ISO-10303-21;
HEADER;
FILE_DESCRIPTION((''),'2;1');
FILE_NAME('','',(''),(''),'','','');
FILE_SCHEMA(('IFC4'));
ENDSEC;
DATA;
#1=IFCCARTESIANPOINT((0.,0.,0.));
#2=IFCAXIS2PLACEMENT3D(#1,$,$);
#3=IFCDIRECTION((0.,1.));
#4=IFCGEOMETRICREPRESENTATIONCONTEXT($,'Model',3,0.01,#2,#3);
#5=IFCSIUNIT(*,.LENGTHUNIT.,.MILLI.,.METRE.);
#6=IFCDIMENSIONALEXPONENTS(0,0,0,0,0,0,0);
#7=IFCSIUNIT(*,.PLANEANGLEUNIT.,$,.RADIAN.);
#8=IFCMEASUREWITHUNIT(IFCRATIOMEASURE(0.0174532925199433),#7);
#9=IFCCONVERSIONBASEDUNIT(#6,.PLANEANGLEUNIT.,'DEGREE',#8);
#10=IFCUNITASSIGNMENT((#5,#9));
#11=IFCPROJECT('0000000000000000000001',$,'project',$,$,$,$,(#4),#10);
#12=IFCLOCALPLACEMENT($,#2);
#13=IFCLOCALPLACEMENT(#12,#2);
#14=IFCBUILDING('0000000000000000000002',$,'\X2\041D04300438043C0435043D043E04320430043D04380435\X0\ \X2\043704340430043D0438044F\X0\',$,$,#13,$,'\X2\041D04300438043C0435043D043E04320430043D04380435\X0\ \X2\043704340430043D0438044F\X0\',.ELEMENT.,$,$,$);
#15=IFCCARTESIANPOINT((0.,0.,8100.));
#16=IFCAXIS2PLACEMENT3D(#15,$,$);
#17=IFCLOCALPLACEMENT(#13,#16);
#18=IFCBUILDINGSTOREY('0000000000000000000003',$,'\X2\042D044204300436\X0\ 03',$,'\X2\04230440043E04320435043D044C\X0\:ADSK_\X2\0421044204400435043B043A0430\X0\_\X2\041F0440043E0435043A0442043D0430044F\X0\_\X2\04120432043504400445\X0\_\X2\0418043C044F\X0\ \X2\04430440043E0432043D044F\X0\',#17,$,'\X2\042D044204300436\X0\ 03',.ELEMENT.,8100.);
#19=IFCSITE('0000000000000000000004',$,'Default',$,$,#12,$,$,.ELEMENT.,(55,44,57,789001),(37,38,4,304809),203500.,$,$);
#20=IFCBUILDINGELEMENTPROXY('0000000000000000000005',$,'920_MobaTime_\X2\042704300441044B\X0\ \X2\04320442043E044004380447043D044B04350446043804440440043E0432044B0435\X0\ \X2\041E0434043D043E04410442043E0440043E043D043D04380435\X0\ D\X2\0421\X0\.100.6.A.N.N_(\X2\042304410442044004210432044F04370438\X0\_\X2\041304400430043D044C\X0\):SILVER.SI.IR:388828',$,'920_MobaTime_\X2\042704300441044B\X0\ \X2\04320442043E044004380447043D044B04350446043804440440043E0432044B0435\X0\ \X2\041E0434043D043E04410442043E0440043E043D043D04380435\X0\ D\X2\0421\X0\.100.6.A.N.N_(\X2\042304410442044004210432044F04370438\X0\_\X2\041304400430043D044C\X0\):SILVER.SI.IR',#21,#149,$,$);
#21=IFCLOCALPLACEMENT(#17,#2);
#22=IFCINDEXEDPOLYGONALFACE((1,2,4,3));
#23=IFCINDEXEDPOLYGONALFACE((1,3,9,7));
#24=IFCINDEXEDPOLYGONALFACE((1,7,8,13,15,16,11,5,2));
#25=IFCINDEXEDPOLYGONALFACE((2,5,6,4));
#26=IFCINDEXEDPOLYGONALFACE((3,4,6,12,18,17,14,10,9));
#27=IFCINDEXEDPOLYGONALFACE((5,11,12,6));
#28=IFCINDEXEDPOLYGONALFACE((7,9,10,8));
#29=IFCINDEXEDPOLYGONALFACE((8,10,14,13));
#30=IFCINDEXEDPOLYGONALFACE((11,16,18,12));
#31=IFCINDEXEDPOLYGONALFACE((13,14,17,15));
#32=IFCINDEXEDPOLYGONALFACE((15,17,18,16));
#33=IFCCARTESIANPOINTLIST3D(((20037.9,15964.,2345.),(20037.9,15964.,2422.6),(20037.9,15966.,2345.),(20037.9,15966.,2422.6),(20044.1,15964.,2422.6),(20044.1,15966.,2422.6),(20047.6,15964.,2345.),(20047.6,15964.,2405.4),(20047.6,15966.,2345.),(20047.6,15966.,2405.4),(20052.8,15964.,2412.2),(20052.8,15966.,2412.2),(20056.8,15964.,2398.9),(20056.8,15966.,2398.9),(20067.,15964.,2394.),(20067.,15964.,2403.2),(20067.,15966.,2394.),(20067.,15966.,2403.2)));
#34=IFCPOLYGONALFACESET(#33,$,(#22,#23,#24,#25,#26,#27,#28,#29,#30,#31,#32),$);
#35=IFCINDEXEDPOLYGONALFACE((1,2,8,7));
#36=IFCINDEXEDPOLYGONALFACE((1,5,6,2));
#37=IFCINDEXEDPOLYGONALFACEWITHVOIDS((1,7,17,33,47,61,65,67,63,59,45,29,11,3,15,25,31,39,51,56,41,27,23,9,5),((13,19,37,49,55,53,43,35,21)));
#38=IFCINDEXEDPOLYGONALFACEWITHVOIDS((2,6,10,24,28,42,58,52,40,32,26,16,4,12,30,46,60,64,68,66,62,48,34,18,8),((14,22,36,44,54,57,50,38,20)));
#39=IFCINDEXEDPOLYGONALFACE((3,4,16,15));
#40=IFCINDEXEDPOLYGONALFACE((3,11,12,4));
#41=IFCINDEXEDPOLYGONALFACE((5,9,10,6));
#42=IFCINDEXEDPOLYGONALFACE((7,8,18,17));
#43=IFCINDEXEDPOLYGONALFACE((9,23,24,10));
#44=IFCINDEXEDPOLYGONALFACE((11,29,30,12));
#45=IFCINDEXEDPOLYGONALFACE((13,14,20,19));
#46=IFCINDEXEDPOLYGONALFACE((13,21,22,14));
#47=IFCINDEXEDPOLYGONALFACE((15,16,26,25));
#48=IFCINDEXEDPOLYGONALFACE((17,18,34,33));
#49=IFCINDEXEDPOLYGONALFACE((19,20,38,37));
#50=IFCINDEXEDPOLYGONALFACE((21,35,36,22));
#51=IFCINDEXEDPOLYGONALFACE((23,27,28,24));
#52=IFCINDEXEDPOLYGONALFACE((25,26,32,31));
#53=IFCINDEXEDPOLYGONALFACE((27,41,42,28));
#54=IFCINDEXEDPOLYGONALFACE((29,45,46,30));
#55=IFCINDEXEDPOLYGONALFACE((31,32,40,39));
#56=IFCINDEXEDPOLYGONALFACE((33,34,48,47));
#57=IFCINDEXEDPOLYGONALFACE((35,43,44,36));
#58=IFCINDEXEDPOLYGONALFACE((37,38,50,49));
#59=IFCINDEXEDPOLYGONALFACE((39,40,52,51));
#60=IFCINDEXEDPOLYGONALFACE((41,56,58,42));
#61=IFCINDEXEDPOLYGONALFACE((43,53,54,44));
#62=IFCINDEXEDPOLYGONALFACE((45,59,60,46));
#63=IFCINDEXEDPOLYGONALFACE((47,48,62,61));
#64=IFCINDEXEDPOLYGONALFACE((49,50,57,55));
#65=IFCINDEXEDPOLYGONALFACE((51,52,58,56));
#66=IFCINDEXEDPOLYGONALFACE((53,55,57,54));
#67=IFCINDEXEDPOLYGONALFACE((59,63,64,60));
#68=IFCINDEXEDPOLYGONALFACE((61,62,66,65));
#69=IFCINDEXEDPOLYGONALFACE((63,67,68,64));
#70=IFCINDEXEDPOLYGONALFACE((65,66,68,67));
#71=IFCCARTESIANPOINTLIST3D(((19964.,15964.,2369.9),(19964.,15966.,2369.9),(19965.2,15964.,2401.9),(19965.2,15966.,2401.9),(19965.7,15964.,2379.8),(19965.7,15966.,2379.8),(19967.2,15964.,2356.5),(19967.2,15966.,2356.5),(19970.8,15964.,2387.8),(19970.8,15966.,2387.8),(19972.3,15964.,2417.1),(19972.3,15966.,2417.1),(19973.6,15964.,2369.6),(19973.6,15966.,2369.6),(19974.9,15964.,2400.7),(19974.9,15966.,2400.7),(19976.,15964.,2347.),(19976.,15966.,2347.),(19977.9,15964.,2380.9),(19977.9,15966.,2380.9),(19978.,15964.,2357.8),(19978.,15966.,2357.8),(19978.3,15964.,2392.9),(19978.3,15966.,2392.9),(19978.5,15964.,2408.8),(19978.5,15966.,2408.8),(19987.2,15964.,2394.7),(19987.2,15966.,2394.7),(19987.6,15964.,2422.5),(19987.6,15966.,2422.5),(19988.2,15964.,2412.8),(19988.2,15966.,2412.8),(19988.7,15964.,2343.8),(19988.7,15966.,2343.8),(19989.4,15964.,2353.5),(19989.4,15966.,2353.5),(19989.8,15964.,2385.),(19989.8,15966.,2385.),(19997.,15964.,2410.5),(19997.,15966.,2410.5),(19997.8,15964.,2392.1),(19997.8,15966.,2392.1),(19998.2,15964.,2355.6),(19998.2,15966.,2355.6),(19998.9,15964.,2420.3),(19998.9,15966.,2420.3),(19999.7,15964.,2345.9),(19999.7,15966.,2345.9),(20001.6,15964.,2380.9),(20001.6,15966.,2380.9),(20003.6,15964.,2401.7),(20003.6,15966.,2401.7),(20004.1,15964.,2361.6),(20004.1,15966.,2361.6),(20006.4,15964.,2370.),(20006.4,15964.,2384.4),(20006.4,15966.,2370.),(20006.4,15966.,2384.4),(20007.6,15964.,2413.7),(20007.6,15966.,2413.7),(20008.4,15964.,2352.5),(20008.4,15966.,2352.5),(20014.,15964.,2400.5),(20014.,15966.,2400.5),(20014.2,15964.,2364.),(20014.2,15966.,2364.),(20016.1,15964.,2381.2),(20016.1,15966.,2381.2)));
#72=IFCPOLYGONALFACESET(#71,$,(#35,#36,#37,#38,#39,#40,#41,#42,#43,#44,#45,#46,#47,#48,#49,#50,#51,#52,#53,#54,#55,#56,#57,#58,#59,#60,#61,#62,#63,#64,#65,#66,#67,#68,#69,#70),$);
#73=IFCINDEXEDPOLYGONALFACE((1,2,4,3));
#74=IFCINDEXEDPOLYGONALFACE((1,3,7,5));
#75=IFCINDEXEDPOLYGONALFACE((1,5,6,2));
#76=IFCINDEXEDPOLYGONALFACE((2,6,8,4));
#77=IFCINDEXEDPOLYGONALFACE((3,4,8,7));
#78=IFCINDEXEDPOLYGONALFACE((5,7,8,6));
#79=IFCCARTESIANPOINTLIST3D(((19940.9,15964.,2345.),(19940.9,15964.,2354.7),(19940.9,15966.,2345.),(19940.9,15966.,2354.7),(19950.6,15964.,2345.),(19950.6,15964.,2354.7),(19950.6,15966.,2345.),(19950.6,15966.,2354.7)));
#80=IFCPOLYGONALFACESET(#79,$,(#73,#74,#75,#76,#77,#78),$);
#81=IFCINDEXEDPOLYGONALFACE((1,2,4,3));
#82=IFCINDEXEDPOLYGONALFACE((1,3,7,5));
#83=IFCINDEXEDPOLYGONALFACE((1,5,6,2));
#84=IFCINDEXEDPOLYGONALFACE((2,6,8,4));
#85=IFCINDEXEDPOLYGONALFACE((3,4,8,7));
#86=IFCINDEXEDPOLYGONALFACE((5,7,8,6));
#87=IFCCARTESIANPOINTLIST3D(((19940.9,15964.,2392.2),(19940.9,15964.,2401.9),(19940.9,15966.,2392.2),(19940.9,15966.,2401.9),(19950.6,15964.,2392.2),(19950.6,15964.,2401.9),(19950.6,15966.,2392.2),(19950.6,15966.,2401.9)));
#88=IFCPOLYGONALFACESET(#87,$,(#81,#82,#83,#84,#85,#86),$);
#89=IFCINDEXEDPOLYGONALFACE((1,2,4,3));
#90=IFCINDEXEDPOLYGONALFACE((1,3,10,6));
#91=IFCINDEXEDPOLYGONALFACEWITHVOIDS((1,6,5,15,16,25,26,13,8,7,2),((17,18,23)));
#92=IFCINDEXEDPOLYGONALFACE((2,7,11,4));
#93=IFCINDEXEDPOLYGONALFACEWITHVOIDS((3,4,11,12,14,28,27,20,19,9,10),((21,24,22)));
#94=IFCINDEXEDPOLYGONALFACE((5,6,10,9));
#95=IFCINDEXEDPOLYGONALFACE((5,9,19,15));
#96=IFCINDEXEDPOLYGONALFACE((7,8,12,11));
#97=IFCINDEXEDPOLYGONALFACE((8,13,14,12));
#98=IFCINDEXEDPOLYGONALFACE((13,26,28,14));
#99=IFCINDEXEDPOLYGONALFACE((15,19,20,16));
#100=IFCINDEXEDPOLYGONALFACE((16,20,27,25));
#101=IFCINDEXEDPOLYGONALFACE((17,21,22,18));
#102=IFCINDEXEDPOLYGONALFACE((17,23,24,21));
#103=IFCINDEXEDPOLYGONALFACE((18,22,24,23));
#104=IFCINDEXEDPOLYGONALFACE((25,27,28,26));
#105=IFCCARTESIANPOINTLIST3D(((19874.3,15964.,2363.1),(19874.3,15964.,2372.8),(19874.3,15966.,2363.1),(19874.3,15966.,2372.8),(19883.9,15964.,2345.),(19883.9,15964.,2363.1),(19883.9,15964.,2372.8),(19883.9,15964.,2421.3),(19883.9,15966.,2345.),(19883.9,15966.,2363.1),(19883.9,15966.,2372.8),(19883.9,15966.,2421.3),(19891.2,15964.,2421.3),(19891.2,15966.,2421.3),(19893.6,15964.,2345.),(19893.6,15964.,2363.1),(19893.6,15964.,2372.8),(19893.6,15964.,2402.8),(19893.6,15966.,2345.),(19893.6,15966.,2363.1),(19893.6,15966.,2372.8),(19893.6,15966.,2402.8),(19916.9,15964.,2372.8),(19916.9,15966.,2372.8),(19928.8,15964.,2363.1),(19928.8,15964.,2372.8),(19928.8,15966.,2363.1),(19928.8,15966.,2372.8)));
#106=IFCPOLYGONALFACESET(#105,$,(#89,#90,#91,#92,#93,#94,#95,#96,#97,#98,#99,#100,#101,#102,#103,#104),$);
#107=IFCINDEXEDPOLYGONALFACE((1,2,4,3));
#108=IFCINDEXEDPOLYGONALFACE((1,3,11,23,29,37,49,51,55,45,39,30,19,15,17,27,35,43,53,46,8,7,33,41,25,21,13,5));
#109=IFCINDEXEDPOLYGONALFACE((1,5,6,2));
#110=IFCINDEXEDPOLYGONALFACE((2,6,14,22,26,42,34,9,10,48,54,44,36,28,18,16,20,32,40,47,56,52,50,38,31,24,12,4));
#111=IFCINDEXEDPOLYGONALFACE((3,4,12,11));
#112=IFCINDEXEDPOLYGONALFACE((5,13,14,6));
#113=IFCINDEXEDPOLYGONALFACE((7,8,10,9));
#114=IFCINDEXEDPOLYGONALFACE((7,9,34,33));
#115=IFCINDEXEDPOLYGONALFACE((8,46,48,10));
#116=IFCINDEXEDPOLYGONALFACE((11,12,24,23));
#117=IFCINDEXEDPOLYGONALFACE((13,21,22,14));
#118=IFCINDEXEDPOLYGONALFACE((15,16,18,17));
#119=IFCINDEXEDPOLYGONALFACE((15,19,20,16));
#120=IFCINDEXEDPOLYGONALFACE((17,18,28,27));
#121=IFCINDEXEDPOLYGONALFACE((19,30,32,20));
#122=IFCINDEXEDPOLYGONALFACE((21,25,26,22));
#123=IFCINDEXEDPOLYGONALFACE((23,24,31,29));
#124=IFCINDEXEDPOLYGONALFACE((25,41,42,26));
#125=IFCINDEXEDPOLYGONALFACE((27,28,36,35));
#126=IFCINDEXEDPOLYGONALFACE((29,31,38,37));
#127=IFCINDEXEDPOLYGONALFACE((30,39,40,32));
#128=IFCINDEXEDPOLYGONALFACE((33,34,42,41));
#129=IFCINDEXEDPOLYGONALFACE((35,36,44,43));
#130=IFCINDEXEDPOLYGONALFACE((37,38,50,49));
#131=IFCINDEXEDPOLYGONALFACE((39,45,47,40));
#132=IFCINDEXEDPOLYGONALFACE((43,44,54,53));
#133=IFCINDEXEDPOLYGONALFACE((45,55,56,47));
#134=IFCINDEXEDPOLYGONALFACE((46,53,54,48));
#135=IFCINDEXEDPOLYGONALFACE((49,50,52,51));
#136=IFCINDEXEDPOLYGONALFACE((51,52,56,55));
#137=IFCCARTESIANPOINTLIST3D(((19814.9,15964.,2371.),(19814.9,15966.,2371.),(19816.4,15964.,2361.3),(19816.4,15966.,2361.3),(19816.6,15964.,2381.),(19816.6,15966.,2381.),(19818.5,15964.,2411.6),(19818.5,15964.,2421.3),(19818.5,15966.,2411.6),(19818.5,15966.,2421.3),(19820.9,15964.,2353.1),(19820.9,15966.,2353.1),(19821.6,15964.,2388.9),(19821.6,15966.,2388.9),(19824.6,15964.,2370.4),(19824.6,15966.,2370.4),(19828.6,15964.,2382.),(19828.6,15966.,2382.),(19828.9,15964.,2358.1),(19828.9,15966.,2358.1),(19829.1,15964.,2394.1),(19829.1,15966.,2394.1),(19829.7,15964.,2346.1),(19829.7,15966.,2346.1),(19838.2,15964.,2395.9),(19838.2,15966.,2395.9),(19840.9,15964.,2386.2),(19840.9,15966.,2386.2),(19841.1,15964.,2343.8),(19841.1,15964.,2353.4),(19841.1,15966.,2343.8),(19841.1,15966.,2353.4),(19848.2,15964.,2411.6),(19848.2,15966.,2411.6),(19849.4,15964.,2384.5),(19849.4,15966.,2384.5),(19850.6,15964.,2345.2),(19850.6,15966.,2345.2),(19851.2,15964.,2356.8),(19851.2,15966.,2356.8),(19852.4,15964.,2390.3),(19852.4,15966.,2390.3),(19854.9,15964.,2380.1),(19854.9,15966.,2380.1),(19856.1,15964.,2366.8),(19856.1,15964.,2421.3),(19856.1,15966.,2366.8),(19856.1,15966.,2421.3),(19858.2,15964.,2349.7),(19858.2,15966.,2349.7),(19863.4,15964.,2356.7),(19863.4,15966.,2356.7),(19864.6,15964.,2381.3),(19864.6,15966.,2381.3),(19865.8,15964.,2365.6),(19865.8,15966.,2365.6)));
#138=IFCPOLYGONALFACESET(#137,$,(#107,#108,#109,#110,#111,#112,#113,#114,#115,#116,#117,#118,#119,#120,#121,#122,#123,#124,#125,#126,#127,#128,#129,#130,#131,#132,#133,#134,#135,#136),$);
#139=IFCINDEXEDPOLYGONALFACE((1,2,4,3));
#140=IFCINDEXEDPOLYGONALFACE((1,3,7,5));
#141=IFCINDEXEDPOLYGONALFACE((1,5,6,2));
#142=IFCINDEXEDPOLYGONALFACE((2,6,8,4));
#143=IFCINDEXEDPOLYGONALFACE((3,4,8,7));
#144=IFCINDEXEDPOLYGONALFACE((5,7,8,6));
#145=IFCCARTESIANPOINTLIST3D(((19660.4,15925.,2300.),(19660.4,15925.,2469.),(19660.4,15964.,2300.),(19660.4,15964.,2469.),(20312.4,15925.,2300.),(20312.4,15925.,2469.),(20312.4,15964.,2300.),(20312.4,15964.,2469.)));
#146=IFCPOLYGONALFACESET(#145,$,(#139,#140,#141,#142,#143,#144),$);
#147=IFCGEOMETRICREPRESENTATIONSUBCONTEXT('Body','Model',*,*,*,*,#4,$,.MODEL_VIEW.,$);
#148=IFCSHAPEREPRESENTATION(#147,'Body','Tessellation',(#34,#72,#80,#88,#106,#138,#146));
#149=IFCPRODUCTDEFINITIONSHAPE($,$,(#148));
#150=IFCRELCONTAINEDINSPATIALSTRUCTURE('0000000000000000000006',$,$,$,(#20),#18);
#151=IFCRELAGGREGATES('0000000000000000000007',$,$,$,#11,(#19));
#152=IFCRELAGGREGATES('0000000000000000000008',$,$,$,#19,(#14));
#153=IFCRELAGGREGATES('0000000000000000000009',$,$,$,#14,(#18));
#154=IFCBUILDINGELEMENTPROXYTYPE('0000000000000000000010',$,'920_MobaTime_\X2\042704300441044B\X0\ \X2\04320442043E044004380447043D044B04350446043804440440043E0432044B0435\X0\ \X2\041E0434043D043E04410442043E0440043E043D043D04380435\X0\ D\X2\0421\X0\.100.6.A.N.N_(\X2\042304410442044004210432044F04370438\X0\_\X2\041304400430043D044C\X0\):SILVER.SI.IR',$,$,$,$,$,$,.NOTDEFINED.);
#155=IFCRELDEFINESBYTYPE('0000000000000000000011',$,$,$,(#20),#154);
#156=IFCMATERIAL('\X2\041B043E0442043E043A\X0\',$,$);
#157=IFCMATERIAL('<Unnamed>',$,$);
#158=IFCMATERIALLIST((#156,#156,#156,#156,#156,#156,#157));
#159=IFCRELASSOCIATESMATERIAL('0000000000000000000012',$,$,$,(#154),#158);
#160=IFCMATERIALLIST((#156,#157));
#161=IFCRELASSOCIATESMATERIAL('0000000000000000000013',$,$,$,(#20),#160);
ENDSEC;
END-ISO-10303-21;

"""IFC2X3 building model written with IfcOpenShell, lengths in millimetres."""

from ifc_helpers import new_model, entity, si_unit, converted_unit, direction, frame, origin, origin_2d_with_axis, place, context, subcontext, project, spatial, polyline, rectangle, outline, extrude, source, transform, mapped, material, material_list, type_object, type_shapes, element, save


model = new_model("IFC2X3")

# Units and contexts
model_context = context("Model", 3, precision=0.01, world=origin(), true_north=direction((0.0, 1.0)))
body_context = subcontext(model_context, "Body", "Model", "MODEL_VIEW")
ifc_project = project(units=[si_unit("LENGTHUNIT", "METRE", prefix="MILLI"), converted_unit("PLANEANGLEUNIT", "DEGREE", entity("IfcRatioMeasure", 0.0174532925199433), si_unit("PLANEANGLEUNIT", "RADIAN"), dimensions=[0, 0, 0, 0, 0, 0, 0])], contexts=[model_context])

# Site, building, storey
site_placement = place(None, origin())
site = spatial("IfcSite", under=ifc_project, at=site_placement, Name="Default", CompositionType="ELEMENT", RefLatitude=(55, 44, 57, 789001), RefLongitude=(37, 38, 4, 304809), RefElevation=203500.0)
building_placement = place(site_placement, origin())
building = spatial("IfcBuilding", under=site, at=building_placement, Name="Наименование здания", LongName="Наименование здания", CompositionType="ELEMENT")
storey_placement = place(building_placement, frame((0.0, 0.0, 8100.0)))
storey = spatial("IfcBuildingStorey", under=building, at=storey_placement, Name="Этаж 03", ObjectType="Уровень:ADSK_Стрелка_Проектная_Вверх_Имя уровня", LongName="Этаж 03", CompositionType="ELEMENT", Elevation=8100.0)

# Building element proxy
ifc_material_1 = material(Name="Лоток")
ifc_material_2 = material(Name="<Unnamed>")
ifc_material_list_1 = material_list([ifc_material_1, ifc_material_1, ifc_material_1, ifc_material_1, ifc_material_1, ifc_material_1, ifc_material_2])
building_element_proxy_type = type_object("IfcBuildingElementProxyType", Name="920_MobaTime_Часы вторичныецифровые Односторонние DС.100.6.A.N.N_(УстрСвязи_Грань):SILVER.SI.IR", PredefinedType="NOTDEFINED", material=ifc_material_list_1)
shared_shape = source(origin(), body_context, "Body", "SweptSolid", [
    extrude(outline(polyline([(-49.3, -13.1), (28.2, -13.1), (28.2, -6.8), (17.9, 1.8), (8.8, 16.0), (-0.3, 16.0), (4.6, 5.8), (11.1, -3.4), (-49.3, -3.4), (-49.3, -13.1)])), frame((-64.6, 9.8, 39.0), z_axis=(0.0, 0.0, 1.0), x_axis=(0.0, 1.0, 0.0)), (0.0, 0.0, 1.0), 2.0),
    extrude(outline(polyline([(2.2, -27.6), (19.0, -27.6), (30.5, -16.1), (33.3, -4.9), (31.0, 5.8), (21.8, 17.2), (5.2, 27.3), (-11.1, 33.0), (-24.0, 32.7), (-33.6, 27.6), (-40.3, 18.6), (-42.8, 5.7), (-38.0, -6.3), (-27.2, -14.9), (-17.5, -17.7), (-8.2, -16.4), (-0.3, -11.9), (5.1, -4.5), (7.3, 6.2), (4.0, 17.2), (18.4, 7.3), (23.6, -2.4), (22.0, -11.4), (14.2, -18.4), (5.3, -18.3), (2.2, -27.6)]), holes=[polyline([(-9.0, 23.3), (-1.3, 14.3), (-2.5, 2.0), (-11.4, -7.0), (-23.4, -6.0), (-32.2, 2.9), (-31.2, 15.1), (-25.6, 22.1), (-17.5, 24.9), (-9.0, 23.3)])]), frame((-2.7, 3.6, 39.0), z_axis=(0.0, 0.0, 1.0), x_axis=(-0.427649, 0.903945, 0.0)), (0.0, 0.0, 1.0), 2.0),
    extrude(rectangle(XDim=9.7, YDim=9.7, at=origin_2d_with_axis()), frame((40.6, -34.7, 39.0)), (0.0, 0.0, 1.0), 2.0),
    extrude(rectangle(XDim=9.7, YDim=9.7, at=origin_2d_with_axis()), frame((40.6, 12.6, 39.0)), (0.0, 0.0, 1.0), 2.0),
    extrude(outline(polyline([(-0.9, -28.1), (8.8, -28.1), (8.8, -9.9), (18.5, -9.9), (18.5, -0.2), (8.8, -0.2), (8.8, 48.3), (1.5, 48.3), (-36.0, -0.2), (-36.0, -9.9), (-0.9, -9.9), (-0.9, -28.1)]), holes=[polyline([(-0.9, -0.2), (-24.1, -0.2), (-0.9, 29.7), (-0.9, -0.2)])]), frame((93.6, -11.4, 39.0)), (0.0, 0.0, 1.0), 2.0),
    extrude(outline(polyline([(3.3, -28.3), (12.5, -28.3), (20.5, -25.0), (26.8, -18.9), (30.7, -10.0), (31.4, 1.6), (26.9, 11.8), (20.1, 18.4), (11.1, 22.3), (1.0, 23.3), (-7.9, 20.4), (-14.9, 14.5), (-18.9, 6.2), (-17.1, -9.0), (-36.7, 0.5), (-29.1, 29.2), (-38.5, 31.7), (-48.1, -4.6), (-11.6, -23.1), (-8.0, -14.0), (-10.8, -7.6), (-10.2, 1.1), (-3.0, 11.8), (9.2, 12.8), (20.0, 5.5), (21.4, -7.5), (15.5, -16.4), (4.6, -18.6), (3.3, -28.3)])), frame((147.1, -8.5, 39.0), z_axis=(0.0, 0.0, 1.0), x_axis=(0.256974, -0.966418, 0.0)), (0.0, 0.0, 1.0), 2.0),
    extrude(rectangle(XDim=652.0, YDim=169.0, at=origin_2d_with_axis()), frame((0.0, 0.0, 0.0), z_axis=(0.0, 0.0, 1.0), x_axis=(-1.0, 0.0, 0.0)), (0.0, 0.0, 1.0), 39.0),
])
type_shapes(building_element_proxy_type, [shared_shape])
ifc_material_list_2 = material_list([ifc_material_1, ifc_material_2])
for number, where, z_axis, x_axis, name in (
    (1, (19986.4, 15925.0, 2384.5), (0.0, 1.0, 0.0), (-1.0, 0.0, 0.0), "920_MobaTime_Часы вторичныецифровые Односторонние DС.100.6.A.N.N_(УстрСвязи_Грань):SILVER.SI.IR:388828"),
):
    element("IfcBuildingElementProxy", number, at=place(storey_placement, frame(where, z_axis=z_axis, x_axis=x_axis)), inside=storey, type_object=building_element_proxy_type, material=ifc_material_list_2, Name=name, ObjectType="920_MobaTime_Часы вторичныецифровые Односторонние DС.100.6.A.N.N_(УстрСвязи_Грань):SILVER.SI.IR", context=body_context, shape_type="MappedRepresentation", body=[
        mapped(shared_shape, transform((0.0, 0.0, 0.0), scale=1.0)),
    ])

save(model, "model.ifc")
